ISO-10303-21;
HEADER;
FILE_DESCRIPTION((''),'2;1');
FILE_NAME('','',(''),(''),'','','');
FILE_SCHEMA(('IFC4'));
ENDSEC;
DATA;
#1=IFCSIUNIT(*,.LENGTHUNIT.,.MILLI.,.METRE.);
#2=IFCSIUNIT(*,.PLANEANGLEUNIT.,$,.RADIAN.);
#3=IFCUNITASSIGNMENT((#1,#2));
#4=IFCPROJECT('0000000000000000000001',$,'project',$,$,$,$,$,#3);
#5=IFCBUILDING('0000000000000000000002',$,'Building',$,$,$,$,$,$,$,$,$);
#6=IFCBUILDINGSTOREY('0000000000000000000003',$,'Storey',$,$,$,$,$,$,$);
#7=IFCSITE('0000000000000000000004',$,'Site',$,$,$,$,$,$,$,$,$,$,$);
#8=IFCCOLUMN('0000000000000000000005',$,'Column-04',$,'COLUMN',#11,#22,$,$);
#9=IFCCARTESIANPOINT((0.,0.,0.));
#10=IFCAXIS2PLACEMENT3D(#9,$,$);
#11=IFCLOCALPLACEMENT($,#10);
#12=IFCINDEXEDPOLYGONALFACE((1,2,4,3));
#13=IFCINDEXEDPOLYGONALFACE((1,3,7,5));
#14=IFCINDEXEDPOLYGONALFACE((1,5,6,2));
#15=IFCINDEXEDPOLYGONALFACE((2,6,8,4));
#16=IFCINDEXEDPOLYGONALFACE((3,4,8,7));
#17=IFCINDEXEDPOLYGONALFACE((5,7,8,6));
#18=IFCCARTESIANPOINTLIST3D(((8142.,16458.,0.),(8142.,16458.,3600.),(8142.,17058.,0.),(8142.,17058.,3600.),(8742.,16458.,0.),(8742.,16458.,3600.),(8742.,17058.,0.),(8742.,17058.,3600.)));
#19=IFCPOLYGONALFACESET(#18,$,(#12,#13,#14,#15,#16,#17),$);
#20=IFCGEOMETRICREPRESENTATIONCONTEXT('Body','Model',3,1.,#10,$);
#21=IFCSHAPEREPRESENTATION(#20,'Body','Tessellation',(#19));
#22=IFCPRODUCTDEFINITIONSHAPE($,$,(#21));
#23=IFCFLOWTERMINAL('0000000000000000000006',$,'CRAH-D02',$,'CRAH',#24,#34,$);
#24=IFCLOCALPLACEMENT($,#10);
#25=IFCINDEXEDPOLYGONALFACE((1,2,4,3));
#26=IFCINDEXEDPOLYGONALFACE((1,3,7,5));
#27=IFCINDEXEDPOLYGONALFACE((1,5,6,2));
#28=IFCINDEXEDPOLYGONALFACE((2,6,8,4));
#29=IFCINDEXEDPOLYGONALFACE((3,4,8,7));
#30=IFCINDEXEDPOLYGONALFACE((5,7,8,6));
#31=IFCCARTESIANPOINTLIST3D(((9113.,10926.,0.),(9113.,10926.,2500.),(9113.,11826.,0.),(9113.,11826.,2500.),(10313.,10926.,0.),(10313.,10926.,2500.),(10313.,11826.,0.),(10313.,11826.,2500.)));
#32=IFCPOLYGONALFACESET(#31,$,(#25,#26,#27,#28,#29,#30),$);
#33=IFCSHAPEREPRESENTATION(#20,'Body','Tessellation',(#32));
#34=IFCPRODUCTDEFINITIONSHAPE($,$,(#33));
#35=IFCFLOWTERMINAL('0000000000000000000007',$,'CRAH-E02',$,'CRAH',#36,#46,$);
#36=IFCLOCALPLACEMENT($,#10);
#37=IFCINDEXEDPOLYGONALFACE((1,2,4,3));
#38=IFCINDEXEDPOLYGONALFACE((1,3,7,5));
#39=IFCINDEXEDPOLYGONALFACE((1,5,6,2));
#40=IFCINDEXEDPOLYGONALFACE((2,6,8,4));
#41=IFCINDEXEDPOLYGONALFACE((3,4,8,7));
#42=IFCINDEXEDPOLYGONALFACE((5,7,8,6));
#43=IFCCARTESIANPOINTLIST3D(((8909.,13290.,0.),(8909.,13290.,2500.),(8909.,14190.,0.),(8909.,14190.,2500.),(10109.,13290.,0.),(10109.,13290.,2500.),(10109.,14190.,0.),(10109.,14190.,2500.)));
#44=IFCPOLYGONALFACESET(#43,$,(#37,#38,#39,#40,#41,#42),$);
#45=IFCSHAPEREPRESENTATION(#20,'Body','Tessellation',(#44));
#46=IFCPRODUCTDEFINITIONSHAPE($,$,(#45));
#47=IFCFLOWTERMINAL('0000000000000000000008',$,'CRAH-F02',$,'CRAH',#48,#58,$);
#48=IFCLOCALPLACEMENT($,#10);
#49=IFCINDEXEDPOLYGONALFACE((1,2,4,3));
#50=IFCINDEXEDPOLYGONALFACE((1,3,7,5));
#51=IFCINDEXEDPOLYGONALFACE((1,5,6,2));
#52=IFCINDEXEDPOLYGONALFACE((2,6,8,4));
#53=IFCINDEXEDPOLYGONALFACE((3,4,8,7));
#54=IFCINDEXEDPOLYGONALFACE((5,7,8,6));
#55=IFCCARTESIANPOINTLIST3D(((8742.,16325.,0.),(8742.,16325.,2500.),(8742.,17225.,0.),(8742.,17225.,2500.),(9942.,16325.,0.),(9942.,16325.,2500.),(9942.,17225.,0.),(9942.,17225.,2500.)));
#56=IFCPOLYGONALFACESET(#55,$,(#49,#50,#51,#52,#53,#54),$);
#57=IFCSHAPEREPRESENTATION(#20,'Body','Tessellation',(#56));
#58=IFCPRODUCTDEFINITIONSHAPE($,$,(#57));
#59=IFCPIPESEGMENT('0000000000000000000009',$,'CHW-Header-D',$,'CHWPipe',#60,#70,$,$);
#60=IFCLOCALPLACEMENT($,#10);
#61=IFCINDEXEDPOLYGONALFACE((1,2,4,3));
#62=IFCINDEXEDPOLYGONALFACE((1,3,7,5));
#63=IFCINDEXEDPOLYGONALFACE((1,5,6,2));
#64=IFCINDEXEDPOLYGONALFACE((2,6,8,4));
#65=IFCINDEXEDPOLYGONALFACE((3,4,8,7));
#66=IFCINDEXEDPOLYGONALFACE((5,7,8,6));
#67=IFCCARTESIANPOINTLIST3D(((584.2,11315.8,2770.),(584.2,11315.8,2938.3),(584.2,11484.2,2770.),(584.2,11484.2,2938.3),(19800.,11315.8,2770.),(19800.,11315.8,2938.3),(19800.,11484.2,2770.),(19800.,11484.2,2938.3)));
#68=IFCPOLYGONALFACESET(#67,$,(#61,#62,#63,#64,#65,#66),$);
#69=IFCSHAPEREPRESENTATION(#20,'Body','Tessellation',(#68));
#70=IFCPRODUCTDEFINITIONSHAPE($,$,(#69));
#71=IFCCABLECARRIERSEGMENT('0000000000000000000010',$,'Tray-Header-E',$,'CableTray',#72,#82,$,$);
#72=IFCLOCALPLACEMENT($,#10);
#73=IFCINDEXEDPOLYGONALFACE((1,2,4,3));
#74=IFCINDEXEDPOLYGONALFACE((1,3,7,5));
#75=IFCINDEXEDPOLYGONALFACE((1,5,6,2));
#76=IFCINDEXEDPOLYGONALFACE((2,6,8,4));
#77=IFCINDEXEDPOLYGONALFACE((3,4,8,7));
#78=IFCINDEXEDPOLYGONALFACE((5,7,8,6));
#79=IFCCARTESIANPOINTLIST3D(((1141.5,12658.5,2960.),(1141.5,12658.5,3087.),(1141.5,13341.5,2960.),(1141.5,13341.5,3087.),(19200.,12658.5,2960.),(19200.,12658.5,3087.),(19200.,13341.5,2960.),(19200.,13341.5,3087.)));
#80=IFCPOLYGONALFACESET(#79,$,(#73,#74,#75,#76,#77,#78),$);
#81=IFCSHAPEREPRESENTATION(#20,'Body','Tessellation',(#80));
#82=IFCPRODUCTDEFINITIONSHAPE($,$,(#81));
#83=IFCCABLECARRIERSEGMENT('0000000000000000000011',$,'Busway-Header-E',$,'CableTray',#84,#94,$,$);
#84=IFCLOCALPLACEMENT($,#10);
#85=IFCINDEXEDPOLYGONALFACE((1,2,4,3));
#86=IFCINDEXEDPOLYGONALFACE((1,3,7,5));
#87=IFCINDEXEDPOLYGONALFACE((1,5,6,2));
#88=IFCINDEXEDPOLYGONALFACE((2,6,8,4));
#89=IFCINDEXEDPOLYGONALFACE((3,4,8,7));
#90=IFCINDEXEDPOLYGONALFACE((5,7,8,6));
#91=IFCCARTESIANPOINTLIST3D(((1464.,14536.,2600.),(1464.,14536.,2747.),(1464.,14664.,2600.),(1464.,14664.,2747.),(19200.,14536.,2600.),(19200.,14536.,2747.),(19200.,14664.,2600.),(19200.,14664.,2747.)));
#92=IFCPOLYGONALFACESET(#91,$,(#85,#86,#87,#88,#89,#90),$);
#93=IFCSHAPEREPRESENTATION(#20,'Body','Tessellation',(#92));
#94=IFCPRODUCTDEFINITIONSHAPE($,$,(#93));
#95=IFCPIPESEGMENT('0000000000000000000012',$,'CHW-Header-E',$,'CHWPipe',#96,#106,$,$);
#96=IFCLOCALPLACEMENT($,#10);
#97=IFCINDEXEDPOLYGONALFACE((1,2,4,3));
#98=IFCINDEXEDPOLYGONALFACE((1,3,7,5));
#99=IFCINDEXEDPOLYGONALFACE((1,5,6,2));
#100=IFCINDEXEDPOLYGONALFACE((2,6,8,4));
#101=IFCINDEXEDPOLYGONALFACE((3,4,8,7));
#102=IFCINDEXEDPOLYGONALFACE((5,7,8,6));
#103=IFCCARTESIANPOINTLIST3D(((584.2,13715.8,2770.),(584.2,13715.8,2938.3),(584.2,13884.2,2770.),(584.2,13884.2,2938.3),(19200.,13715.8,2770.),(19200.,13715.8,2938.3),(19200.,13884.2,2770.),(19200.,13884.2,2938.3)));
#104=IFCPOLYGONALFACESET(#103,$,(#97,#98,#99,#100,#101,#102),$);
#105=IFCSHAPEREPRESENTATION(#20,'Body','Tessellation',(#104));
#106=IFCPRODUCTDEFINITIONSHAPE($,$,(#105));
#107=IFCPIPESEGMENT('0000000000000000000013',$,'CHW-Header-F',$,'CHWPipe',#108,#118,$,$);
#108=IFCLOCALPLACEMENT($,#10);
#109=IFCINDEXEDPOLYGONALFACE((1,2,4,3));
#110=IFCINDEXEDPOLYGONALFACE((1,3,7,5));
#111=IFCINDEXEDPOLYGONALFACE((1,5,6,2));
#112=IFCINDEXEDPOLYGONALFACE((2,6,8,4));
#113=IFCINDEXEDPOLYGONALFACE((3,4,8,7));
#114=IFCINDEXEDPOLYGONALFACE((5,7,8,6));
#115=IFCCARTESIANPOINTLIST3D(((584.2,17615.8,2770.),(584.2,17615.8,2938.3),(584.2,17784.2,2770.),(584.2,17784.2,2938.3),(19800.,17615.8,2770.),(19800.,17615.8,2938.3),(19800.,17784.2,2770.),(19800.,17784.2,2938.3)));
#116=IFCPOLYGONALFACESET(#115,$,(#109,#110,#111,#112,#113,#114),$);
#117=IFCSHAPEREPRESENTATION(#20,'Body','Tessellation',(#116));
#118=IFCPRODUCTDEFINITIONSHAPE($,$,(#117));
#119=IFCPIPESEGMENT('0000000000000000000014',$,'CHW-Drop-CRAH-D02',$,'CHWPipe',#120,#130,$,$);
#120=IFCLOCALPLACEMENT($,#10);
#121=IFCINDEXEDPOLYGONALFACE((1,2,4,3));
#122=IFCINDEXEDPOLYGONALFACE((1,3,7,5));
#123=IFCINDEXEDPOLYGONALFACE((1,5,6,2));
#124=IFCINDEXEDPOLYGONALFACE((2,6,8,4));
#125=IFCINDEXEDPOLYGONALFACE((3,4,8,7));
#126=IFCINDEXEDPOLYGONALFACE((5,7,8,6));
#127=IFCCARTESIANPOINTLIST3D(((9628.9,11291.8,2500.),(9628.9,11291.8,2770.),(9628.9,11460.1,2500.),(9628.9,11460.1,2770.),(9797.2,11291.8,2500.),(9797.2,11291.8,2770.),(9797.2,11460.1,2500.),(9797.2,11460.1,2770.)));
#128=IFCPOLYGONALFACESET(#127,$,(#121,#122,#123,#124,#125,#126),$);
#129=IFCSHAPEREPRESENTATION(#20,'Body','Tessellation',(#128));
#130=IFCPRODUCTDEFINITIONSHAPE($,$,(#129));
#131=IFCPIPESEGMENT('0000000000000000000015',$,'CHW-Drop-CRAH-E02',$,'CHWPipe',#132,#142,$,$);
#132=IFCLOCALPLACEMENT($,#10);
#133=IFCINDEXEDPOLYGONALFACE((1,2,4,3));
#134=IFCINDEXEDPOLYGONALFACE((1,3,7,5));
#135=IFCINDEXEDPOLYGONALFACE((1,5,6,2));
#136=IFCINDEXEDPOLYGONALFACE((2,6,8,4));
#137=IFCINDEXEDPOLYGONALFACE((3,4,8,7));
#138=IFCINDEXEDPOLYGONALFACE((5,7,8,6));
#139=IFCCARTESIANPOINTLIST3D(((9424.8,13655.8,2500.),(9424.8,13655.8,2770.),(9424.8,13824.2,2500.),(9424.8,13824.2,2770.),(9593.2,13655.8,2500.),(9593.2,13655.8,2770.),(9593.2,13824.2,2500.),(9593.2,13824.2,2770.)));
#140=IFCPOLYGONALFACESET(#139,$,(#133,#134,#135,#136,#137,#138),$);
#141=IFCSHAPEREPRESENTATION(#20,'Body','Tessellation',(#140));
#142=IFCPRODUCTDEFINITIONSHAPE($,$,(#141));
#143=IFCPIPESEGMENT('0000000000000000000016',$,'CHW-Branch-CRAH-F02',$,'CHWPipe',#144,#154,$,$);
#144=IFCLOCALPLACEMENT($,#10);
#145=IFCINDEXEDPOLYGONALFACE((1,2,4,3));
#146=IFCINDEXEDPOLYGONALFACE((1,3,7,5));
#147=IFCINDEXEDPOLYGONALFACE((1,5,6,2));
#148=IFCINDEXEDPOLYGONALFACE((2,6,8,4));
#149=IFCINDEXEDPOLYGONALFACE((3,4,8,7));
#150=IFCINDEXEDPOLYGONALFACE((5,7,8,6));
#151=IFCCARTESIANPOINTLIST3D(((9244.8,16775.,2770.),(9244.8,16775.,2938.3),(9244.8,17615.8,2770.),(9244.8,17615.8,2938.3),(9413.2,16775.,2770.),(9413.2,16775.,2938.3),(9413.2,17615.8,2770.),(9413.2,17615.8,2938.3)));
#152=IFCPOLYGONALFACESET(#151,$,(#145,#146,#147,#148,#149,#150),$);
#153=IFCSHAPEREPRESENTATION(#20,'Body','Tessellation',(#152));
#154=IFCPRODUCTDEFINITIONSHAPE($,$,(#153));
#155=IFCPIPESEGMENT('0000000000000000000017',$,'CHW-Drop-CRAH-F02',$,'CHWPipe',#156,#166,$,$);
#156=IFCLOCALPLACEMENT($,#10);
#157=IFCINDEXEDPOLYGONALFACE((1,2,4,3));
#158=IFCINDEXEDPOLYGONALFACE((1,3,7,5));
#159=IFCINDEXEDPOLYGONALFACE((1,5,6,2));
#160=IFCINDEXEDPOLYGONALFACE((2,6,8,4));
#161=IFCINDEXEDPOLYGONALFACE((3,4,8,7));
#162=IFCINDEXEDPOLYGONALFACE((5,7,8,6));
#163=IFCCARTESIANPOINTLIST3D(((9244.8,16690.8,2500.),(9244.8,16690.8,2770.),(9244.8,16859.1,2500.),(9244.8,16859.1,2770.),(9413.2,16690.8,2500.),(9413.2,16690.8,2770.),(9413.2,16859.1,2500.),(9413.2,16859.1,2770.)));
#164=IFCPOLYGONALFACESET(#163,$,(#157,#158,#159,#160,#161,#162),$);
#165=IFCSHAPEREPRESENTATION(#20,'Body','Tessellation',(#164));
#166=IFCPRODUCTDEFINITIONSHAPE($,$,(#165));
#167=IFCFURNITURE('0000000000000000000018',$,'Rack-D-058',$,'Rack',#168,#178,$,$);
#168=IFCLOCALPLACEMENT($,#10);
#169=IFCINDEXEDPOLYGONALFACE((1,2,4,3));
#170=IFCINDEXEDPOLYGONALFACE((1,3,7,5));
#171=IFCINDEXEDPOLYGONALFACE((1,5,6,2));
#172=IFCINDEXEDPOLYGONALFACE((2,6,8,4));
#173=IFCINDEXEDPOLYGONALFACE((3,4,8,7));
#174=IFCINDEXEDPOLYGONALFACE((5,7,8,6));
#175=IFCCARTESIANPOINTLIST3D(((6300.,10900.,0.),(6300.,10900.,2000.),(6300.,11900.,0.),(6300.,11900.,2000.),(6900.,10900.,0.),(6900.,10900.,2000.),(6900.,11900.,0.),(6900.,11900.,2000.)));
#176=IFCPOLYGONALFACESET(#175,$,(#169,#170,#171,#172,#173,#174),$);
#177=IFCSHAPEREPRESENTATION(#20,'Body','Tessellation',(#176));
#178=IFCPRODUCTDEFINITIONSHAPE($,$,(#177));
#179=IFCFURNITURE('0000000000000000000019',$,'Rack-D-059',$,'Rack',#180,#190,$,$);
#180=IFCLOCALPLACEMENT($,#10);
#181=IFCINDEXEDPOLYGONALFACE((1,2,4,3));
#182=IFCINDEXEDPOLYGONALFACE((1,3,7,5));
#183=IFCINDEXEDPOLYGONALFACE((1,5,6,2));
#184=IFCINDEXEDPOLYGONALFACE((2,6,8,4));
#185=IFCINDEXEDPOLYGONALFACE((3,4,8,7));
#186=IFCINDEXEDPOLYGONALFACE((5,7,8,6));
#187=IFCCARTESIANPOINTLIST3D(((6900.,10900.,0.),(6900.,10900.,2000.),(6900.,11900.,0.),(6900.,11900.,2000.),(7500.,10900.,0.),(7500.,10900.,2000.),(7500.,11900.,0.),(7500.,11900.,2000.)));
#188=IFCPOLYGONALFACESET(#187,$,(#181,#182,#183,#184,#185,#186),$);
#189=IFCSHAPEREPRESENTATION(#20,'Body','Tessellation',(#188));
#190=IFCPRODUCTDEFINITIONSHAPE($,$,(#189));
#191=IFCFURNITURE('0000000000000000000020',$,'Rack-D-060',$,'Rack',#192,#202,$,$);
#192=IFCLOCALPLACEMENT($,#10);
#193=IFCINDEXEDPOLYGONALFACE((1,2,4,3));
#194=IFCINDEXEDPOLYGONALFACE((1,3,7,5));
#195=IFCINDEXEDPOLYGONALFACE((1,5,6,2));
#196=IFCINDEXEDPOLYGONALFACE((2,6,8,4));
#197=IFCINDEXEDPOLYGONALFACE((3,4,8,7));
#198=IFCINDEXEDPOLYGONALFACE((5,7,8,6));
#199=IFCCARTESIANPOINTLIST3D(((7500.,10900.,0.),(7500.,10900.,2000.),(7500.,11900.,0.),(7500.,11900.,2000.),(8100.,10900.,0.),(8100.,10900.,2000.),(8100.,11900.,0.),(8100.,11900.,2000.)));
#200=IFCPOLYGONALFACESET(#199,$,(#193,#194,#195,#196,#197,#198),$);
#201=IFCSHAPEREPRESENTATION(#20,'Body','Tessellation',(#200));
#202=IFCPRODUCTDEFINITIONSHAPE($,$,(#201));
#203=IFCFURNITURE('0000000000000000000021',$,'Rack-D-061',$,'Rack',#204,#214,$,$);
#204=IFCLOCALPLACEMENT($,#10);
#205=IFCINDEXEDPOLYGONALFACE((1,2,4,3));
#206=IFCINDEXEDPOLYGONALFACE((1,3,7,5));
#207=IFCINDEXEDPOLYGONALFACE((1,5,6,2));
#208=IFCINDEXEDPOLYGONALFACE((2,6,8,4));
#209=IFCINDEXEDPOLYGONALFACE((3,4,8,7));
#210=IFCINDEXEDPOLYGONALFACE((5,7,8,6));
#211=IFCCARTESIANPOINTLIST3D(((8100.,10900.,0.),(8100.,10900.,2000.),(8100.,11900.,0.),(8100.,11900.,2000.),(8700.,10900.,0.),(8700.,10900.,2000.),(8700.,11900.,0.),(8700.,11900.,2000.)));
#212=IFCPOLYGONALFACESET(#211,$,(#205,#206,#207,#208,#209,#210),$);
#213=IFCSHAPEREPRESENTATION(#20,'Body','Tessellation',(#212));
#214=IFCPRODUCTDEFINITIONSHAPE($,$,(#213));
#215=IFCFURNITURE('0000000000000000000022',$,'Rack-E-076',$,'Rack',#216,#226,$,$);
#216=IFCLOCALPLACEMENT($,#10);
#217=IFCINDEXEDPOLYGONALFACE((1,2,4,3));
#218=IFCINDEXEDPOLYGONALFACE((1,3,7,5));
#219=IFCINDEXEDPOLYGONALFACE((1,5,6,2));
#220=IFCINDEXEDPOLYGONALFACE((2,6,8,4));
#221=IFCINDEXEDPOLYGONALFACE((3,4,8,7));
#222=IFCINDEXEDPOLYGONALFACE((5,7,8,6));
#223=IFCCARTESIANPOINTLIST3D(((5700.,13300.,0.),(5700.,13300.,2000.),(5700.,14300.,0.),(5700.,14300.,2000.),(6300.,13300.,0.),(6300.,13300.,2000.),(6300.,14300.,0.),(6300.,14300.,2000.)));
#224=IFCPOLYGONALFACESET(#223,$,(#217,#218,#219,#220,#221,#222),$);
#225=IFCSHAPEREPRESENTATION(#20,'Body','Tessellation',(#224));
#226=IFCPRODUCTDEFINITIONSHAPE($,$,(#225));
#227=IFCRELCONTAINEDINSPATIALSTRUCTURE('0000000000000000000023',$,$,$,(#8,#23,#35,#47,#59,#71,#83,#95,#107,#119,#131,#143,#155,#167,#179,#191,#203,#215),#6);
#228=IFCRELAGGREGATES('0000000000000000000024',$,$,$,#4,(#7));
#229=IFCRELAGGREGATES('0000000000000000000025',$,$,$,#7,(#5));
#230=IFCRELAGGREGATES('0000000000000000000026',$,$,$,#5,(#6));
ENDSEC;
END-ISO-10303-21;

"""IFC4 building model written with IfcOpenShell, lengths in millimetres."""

from ifc_helpers import new_model, si_unit, frame, origin, place, context, project, spatial, rectangle, extrude, element, save


model = new_model("IFC4")

# Units and contexts
model_context = context("Model", 3, precision=1.0, world=origin(), identifier="Body")
ifc_project = project(units=[si_unit("LENGTHUNIT", "METRE", prefix="MILLI"), si_unit("PLANEANGLEUNIT", "RADIAN")])

# Site, building, storey
site = spatial("IfcSite", under=ifc_project, Name="Site")
building = spatial("IfcBuilding", under=site, Name="Building")
storey = spatial("IfcBuildingStorey", under=building, Name="Storey")

# Column
column_placement = place(None, frame((8442.0, 16758.0, 0.0), z_axis=(0.0, 0.0, 1.0), x_axis=(1.0, 0.0, 0.0)))
element("IfcColumn", 1, at=column_placement, inside=storey, Name="Column-04", ObjectType="COLUMN", context=model_context, shape_type="SweptSolid", body=[
    extrude(rectangle(XDim=600.0, YDim=600.0), origin(), (0.0, 0.0, 1.0), 3600.0),
])

# Flow terminals
for number, where, z_axis, x_axis, name in (
    (2, (9713.0, 11376.0, 0.0), (0.0, 0.0, 1.0), (1.0, 0.0, 0.0), "CRAH-D02"),
    (3, (9509.0, 13740.0, 0.0), (0.0, 0.0, 1.0), (1.0, 0.0, 0.0), "CRAH-E02"),
    (4, (9342.0, 16775.0, 0.0), (0.0, 0.0, 1.0), (1.0, 0.0, 0.0), "CRAH-F02"),
):
    element("IfcFlowTerminal", number, at=place(None, frame(where, z_axis=z_axis, x_axis=x_axis)), inside=storey, Name=name, ObjectType="CRAH", context=model_context, shape_type="SweptSolid", body=[
        extrude(rectangle(XDim=1200.0, YDim=900.0), origin(), (0.0, 0.0, 1.0), 2500.0),
    ])

# Pipe segment
pipe_segment_1_placement = place(None, frame((10192.1, 11400.0, 2770.0), z_axis=(0.0, 0.0, 1.0), x_axis=(1.0, 0.0, 0.0)))
element("IfcPipeSegment", 5, at=pipe_segment_1_placement, inside=storey, Name="CHW-Header-D", ObjectType="CHWPipe", context=model_context, shape_type="SweptSolid", body=[
    extrude(rectangle(XDim=19215.8, YDim=168.3), origin(), (0.0, 0.0, 1.0), 168.3),
])

# Cable carrier segments
cable_carrier_segment_1_placement = place(None, frame((10170.8, 13000.0, 2960.0), z_axis=(0.0, 0.0, 1.0), x_axis=(1.0, 0.0, 0.0)))
element("IfcCableCarrierSegment", 6, at=cable_carrier_segment_1_placement, inside=storey, Name="Tray-Header-E", ObjectType="CableTray", context=model_context, shape_type="SweptSolid", body=[
    extrude(rectangle(XDim=18058.5, YDim=683.0), origin(), (0.0, 0.0, 1.0), 127.0),
])
cable_carrier_segment_2_placement = place(None, frame((10332.0, 14600.0, 2600.0), z_axis=(0.0, 0.0, 1.0), x_axis=(1.0, 0.0, 0.0)))
element("IfcCableCarrierSegment", 7, at=cable_carrier_segment_2_placement, inside=storey, Name="Busway-Header-E", ObjectType="CableTray", context=model_context, shape_type="SweptSolid", body=[
    extrude(rectangle(XDim=17736.0, YDim=128.0), origin(), (0.0, 0.0, 1.0), 147.0),
])

# Pipe segments
pipe_segment_2_placement = place(None, frame((9892.1, 13800.0, 2770.0), z_axis=(0.0, 0.0, 1.0), x_axis=(1.0, 0.0, 0.0)))
element("IfcPipeSegment", 8, at=pipe_segment_2_placement, inside=storey, Name="CHW-Header-E", ObjectType="CHWPipe", context=model_context, shape_type="SweptSolid", body=[
    extrude(rectangle(XDim=18615.8, YDim=168.3), origin(), (0.0, 0.0, 1.0), 168.3),
])
pipe_segment_3_placement = place(None, frame((10192.1, 17700.0, 2770.0), z_axis=(0.0, 0.0, 1.0), x_axis=(1.0, 0.0, 0.0)))
element("IfcPipeSegment", 9, at=pipe_segment_3_placement, inside=storey, Name="CHW-Header-F", ObjectType="CHWPipe", context=model_context, shape_type="SweptSolid", body=[
    extrude(rectangle(XDim=19215.8, YDim=168.3), origin(), (0.0, 0.0, 1.0), 168.3),
])
for number, where, z_axis, x_axis, name in (
    (10, (9713.0, 11376.0, 2500.0), (0.0, 0.0, 1.0), (1.0, 0.0, 0.0), "CHW-Drop-CRAH-D02"),
    (11, (9509.0, 13740.0, 2500.0), (0.0, 0.0, 1.0), (1.0, 0.0, 0.0), "CHW-Drop-CRAH-E02"),
):
    element("IfcPipeSegment", number, at=place(None, frame(where, z_axis=z_axis, x_axis=x_axis)), inside=storey, Name=name, ObjectType="CHWPipe", context=model_context, shape_type="SweptSolid", body=[
        extrude(rectangle(XDim=168.3, YDim=168.3), origin(), (0.0, 0.0, 1.0), 270.0),
    ])
pipe_segment_4_placement = place(None, frame((9329.0, 17195.4, 2770.0), z_axis=(0.0, 0.0, 1.0), x_axis=(1.0, 0.0, 0.0)))
element("IfcPipeSegment", 12, at=pipe_segment_4_placement, inside=storey, Name="CHW-Branch-CRAH-F02", ObjectType="CHWPipe", context=model_context, shape_type="SweptSolid", body=[
    extrude(rectangle(XDim=168.3, YDim=840.8), origin(), (0.0, 0.0, 1.0), 168.3),
])
pipe_segment_5_placement = place(None, frame((9329.0, 16775.0, 2500.0), z_axis=(0.0, 0.0, 1.0), x_axis=(1.0, 0.0, 0.0)))
element("IfcPipeSegment", 13, at=pipe_segment_5_placement, inside=storey, Name="CHW-Drop-CRAH-F02", ObjectType="CHWPipe", context=model_context, shape_type="SweptSolid", body=[
    extrude(rectangle(XDim=168.3, YDim=168.3), origin(), (0.0, 0.0, 1.0), 270.0),
])

# Furniture
for number, where, z_axis, x_axis, name in (
    (14, (6600.0, 11400.0, 0.0), (0.0, 0.0, 1.0), (1.0, 0.0, 0.0), "Rack-D-058"),
    (15, (7200.0, 11400.0, 0.0), (0.0, 0.0, 1.0), (1.0, 0.0, 0.0), "Rack-D-059"),
    (16, (7800.0, 11400.0, 0.0), (0.0, 0.0, 1.0), (1.0, 0.0, 0.0), "Rack-D-060"),
    (17, (8400.0, 11400.0, 0.0), (0.0, 0.0, 1.0), (1.0, 0.0, 0.0), "Rack-D-061"),
    (18, (6000.0, 13800.0, 0.0), (0.0, 0.0, 1.0), (1.0, 0.0, 0.0), "Rack-E-076"),
):
    element("IfcFurniture", number, at=place(None, frame(where, z_axis=z_axis, x_axis=x_axis)), inside=storey, Name=name, ObjectType="Rack", context=model_context, shape_type="SweptSolid", body=[
        extrude(rectangle(XDim=600.0, YDim=1000.0), origin(), (0.0, 0.0, 1.0), 2000.0),
    ])

save(model, "model.ifc")
